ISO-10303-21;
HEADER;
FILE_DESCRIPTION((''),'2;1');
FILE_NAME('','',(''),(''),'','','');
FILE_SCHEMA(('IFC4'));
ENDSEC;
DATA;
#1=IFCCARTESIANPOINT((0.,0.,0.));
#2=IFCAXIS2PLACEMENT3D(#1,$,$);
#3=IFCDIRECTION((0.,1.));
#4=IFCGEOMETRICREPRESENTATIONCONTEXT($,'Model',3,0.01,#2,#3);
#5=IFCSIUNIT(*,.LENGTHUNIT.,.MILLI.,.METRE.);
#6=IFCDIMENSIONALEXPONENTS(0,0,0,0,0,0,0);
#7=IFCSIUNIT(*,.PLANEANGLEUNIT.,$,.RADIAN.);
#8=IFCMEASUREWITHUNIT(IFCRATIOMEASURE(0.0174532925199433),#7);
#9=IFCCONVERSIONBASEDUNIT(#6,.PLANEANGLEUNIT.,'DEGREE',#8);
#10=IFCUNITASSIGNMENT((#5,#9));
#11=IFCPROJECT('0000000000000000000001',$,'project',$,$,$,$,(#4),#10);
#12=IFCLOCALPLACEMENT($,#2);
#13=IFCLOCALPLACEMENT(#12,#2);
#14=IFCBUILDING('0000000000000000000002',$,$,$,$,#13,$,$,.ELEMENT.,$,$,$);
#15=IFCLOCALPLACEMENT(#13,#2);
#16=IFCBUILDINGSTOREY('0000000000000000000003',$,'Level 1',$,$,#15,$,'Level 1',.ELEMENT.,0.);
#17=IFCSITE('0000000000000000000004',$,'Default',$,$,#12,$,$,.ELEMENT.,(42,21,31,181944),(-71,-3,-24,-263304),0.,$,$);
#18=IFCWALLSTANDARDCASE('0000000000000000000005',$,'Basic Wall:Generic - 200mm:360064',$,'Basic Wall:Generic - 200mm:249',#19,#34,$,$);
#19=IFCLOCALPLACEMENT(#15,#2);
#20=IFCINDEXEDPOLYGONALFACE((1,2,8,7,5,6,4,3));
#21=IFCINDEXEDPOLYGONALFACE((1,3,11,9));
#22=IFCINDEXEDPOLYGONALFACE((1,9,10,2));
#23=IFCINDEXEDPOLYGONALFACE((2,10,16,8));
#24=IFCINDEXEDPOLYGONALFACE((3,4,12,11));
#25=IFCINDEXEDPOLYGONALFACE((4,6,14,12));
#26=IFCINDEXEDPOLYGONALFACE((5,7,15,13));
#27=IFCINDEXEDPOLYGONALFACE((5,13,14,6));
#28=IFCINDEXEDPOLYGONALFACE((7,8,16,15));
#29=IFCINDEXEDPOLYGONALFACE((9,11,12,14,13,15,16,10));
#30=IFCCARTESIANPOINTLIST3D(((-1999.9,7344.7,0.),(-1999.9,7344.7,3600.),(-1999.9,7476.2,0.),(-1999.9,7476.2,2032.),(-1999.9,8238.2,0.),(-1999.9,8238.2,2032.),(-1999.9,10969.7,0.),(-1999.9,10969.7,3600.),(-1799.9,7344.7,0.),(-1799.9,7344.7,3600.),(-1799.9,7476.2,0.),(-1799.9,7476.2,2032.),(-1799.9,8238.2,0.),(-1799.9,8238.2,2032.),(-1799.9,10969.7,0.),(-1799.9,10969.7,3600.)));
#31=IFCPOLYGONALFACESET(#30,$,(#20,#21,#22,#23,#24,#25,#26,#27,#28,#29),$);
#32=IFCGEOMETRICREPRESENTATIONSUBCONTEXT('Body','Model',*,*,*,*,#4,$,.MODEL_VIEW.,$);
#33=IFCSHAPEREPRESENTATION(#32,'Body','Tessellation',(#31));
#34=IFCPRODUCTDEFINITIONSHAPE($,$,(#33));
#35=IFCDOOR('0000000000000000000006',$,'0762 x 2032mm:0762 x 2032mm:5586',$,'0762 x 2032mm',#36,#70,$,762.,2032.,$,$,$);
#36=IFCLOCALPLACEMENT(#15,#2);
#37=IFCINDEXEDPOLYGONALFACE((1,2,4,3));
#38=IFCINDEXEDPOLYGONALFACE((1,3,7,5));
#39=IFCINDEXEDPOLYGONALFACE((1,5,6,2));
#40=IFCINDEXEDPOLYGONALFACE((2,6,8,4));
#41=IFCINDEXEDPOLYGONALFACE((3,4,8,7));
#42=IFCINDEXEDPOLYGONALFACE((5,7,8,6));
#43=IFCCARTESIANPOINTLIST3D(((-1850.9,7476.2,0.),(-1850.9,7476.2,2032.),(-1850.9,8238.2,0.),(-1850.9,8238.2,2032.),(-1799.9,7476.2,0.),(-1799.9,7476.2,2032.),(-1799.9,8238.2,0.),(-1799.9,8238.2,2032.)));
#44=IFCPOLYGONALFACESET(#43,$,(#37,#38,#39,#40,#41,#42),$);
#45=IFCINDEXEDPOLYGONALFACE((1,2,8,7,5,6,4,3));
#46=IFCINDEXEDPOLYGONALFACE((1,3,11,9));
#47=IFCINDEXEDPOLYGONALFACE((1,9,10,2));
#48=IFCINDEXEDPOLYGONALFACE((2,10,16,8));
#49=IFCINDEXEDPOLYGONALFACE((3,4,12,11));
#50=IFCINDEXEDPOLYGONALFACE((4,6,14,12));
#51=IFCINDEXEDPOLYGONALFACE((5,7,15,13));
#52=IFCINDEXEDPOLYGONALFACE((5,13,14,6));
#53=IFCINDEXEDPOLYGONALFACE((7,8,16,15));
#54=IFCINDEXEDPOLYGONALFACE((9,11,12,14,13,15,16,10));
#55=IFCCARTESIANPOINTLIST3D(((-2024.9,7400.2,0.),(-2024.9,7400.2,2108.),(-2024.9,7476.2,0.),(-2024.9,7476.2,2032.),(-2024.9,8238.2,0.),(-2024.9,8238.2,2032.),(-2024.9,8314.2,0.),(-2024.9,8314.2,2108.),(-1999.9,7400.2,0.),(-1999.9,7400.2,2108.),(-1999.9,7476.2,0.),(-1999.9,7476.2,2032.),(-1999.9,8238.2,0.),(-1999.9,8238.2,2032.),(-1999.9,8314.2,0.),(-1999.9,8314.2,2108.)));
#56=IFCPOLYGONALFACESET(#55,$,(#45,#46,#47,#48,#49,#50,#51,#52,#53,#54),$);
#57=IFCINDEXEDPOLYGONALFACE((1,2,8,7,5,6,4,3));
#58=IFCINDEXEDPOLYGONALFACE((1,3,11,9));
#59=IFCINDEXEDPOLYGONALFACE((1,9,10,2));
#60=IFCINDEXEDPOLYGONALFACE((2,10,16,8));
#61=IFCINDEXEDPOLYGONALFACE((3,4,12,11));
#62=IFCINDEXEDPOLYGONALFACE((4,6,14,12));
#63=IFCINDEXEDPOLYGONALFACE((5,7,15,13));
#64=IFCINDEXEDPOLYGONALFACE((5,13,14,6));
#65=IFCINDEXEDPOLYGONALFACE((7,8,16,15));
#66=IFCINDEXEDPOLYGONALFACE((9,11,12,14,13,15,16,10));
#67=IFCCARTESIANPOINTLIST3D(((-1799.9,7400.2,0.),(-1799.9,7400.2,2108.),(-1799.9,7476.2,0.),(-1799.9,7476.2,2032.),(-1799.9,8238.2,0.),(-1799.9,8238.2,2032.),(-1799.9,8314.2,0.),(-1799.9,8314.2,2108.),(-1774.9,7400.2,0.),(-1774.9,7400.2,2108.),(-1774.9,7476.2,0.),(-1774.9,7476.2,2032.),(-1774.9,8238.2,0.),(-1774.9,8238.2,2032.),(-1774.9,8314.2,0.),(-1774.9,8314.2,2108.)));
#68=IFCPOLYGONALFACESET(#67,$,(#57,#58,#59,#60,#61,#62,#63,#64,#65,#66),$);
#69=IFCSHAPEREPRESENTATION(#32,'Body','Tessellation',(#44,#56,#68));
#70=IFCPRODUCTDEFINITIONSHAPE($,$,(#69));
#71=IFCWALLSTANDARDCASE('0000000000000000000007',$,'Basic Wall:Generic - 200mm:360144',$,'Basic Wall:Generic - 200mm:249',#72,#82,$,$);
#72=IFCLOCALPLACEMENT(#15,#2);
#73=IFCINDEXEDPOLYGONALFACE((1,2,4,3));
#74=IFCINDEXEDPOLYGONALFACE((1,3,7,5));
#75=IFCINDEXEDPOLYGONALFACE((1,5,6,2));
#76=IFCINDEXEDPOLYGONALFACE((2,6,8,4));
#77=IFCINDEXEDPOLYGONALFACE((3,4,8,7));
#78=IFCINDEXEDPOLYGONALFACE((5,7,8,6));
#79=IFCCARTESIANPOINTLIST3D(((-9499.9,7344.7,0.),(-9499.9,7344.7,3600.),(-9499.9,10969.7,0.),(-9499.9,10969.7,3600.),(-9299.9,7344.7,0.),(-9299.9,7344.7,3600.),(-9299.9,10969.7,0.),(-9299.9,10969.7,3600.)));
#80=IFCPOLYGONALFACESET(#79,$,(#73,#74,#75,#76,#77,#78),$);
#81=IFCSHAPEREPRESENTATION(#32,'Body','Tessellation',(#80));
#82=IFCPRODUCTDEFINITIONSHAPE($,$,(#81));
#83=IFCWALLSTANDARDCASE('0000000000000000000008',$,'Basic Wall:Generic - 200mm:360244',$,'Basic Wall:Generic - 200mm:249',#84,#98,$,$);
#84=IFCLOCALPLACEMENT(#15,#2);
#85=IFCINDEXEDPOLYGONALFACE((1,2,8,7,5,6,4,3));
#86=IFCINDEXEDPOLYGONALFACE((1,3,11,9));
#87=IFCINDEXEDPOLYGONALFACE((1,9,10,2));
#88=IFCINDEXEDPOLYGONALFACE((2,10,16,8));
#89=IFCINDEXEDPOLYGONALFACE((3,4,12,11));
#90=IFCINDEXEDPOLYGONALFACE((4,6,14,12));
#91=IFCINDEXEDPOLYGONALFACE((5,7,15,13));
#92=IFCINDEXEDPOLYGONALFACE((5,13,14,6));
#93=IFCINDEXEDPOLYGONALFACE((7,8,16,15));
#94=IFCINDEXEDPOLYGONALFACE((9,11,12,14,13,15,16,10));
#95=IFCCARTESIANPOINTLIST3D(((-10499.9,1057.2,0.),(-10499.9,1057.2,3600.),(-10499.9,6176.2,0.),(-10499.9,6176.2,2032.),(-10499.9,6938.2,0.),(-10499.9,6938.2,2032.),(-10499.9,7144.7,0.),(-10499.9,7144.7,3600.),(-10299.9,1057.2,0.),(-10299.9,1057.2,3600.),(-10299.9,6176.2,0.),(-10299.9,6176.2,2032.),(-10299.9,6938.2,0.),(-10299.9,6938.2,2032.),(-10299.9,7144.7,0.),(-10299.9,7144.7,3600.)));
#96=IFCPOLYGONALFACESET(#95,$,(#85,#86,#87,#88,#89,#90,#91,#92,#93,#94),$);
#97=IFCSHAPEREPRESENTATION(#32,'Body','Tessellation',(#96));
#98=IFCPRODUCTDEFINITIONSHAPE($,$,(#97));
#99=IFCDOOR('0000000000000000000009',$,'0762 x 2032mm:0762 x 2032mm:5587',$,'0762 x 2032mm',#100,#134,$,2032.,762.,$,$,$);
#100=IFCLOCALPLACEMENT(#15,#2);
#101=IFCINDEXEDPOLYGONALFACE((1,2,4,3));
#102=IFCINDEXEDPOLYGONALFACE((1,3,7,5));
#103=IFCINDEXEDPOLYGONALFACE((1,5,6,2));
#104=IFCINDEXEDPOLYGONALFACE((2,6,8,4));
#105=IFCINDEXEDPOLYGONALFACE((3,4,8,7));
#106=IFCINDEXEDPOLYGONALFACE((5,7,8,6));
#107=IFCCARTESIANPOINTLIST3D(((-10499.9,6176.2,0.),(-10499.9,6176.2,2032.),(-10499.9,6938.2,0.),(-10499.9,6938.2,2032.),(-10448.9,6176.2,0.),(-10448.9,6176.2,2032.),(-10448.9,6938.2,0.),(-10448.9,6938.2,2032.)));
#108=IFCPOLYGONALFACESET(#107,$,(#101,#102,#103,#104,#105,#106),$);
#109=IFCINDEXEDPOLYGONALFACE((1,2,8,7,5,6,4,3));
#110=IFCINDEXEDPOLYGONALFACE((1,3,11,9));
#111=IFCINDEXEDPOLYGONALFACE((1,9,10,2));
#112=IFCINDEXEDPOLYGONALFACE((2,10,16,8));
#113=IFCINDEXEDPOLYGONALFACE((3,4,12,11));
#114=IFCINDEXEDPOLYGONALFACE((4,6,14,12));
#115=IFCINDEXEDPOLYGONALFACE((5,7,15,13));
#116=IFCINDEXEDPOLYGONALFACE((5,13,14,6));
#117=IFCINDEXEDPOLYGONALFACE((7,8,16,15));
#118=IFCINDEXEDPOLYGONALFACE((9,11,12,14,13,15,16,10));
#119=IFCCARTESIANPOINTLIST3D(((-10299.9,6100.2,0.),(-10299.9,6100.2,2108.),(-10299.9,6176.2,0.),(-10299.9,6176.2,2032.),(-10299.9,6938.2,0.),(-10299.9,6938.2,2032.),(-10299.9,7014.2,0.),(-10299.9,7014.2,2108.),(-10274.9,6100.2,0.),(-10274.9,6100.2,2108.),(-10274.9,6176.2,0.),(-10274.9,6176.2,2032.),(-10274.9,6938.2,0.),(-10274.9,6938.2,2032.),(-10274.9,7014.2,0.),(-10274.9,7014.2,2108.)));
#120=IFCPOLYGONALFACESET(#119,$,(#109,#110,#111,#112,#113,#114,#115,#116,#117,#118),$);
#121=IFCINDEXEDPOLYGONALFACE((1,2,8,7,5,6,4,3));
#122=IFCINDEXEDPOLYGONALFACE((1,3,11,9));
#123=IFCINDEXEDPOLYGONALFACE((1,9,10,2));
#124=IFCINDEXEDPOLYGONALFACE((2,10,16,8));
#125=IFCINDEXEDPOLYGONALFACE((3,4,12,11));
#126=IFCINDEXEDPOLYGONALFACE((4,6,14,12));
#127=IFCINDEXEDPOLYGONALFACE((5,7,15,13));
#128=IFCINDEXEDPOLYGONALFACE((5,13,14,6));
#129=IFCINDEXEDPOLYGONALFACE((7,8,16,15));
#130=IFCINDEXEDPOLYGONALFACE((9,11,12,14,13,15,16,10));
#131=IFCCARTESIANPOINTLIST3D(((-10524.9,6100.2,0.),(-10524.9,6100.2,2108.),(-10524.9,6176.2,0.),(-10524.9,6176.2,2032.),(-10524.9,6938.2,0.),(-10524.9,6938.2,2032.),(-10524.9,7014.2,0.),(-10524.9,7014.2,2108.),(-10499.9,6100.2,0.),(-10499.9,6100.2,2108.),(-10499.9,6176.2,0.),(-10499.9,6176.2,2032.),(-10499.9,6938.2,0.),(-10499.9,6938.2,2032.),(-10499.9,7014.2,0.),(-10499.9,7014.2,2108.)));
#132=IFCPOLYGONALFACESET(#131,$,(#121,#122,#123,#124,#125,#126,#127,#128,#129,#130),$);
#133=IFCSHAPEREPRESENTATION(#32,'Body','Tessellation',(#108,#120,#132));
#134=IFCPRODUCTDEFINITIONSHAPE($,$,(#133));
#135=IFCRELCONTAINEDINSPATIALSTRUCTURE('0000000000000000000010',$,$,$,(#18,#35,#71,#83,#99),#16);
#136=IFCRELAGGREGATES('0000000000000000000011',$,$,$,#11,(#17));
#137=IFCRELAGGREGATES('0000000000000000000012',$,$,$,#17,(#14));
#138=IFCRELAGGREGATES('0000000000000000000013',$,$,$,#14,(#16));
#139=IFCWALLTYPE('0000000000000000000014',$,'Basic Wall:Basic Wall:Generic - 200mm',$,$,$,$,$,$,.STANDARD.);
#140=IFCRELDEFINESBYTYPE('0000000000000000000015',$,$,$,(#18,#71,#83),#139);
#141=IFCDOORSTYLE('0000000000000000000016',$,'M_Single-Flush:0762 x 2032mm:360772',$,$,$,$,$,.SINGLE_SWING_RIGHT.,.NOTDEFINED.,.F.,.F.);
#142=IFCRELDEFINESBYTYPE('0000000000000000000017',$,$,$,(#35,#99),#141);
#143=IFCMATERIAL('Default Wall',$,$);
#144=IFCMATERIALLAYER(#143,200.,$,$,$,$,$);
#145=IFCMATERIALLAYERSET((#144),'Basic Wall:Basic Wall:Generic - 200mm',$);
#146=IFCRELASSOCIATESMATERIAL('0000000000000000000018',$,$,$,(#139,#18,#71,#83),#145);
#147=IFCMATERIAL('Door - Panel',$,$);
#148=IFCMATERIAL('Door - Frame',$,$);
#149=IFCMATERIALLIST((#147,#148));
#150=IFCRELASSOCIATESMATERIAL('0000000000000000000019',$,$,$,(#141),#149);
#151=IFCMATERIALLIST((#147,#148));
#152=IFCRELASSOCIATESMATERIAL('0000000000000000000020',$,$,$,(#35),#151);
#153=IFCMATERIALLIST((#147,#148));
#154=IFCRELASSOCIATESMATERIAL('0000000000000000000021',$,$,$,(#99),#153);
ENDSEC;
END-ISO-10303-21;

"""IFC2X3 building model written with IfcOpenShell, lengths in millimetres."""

from ifc_helpers import new_model, entity, si_unit, converted_unit, direction, frame, frame_2d, origin, origin_2d_with_axis, place, context, subcontext, project, spatial, polyline, rectangle, outline, extrude, source, transform, mapped, material, material_list, layer, layer_set, layer_usage, type_object, type_shapes, element, fill, save


model = new_model("IFC2X3")

# Units and contexts
model_context = context("Model", 3, precision=0.01, world=origin(), true_north=direction((0.0, 1.0)))
body_context = subcontext(model_context, "Body", "Model", "MODEL_VIEW")
ifc_project = project(units=[si_unit("LENGTHUNIT", "METRE", prefix="MILLI"), converted_unit("PLANEANGLEUNIT", "DEGREE", entity("IfcRatioMeasure", 0.0174532925199433), si_unit("PLANEANGLEUNIT", "RADIAN"), dimensions=[0, 0, 0, 0, 0, 0, 0])], contexts=[model_context])

# Site, building, storey
site_placement = place(None, origin())
site = spatial("IfcSite", under=ifc_project, at=site_placement, Name="Default", CompositionType="ELEMENT", RefLatitude=(42, 21, 31, 181944), RefLongitude=(-71, -3, -24, -263304), RefElevation=0.0)
building_placement = place(site_placement, origin())
building = spatial("IfcBuilding", under=site, at=building_placement, CompositionType="ELEMENT")
storey_placement = place(building_placement, origin())
storey = spatial("IfcBuildingStorey", under=building, at=storey_placement, Name="Level 1", LongName="Level 1", CompositionType="ELEMENT", Elevation=0.0)

# Shared definitions
ifc_material_1 = material(Name="Default Wall")
ifc_material_2 = material(Name="Door - Panel")
ifc_material_3 = material(Name="Door - Frame")

# Shared definitions
ifc_layer_1 = layer(ifc_material_1, 200.0)
ifc_layer_set_1 = layer_set([ifc_layer_1], Name="Basic Wall:Basic Wall:Generic - 200mm")
wall_type_1 = type_object("IfcWallType", Name="Basic Wall:Basic Wall:Generic - 200mm", PredefinedType="STANDARD", material=ifc_layer_set_1)

# Shared definitions
ifc_material_list_1 = material_list([ifc_material_2, ifc_material_3])
door_style_1 = type_object("IfcDoorStyle", Name="M_Single-Flush:0762 x 2032mm:360772", ConstructionType="NOTDEFINED", OperationType="SINGLE_SWING_RIGHT", ParameterTakesPrecedence=False, Sizeable=False, material=ifc_material_list_1)
shared_shape_1 = source(origin(), body_context, "Body", "SweptSolid", [
    extrude(rectangle(XDim=762.0, YDim=51.0, at=frame_2d((0.0, 0.0), x_axis=(1.0, 0.0))), frame((381.0, -27.5, 0.0), z_axis=(0.0, 0.0, 1.0), x_axis=(-1.0, 0.0, 0.0)), (0.0, 0.0, 1.0), 2032.0),
    extrude(outline(polyline([(-457.0, -1035.0), (-381.0, -1035.0), (-381.0, 997.0), (381.0, 997.0), (381.0, -1035.0), (457.0, -1035.0), (457.0, 1073.0), (-457.0, 1073.0), (-457.0, -1035.0)])), frame((381.0, -227.0, 1035.0), z_axis=(0.0, 1.0, 0.0), x_axis=(-1.0, 0.0, 0.0)), (0.0, 0.0, 1.0), 25.0),
    extrude(outline(polyline([(-1073.0, -457.0), (1035.0, -457.0), (1035.0, -381.0), (-997.0, -381.0), (-997.0, 381.0), (1035.0, 381.0), (1035.0, 457.0), (-1073.0, 457.0), (-1073.0, -457.0)])), frame((381.0, -2.0, 1035.0), z_axis=(0.0, 1.0, 0.0), x_axis=(0.0, 0.0, -1.0)), (0.0, 0.0, 1.0), 25.0),
])
type_shapes(door_style_1, [shared_shape_1])

# Wall, opening, door
ifc_layer_usage_1 = layer_usage(ifc_layer_set_1, "AXIS2", "NEGATIVE", 100.0)
wall_1_placement = place(storey_placement, frame((-1899.9, 10969.7, 0.0), z_axis=(0.0, 0.0, 1.0), x_axis=(0.0, -1.0, 0.0)))
wall_1 = element("IfcWallStandardCase", 1, at=wall_1_placement, inside=storey, type_object=wall_type_1, material=ifc_layer_usage_1, Name="Basic Wall:Generic - 200mm:360064", ObjectType="Basic Wall:Generic - 200mm:249", context=body_context, shape_type="SweptSolid", body=[
    extrude(rectangle(XDim=3625.0, YDim=200.0, at=frame_2d((1812.5, 0.0), x_axis=(-1.0, 0.0))), origin(), (0.0, 0.0, 1.0), 3600.0),
])
opening_1_placement = place(wall_1_placement, frame((10969.7, 1899.9, 0.0), z_axis=(0.0, 0.0, 1.0), x_axis=(0.0, 1.0, 0.0)))
opening_1 = element("IfcOpeningElement", 2, at=opening_1_placement, cuts=wall_1, ObjectType="Opening", context=body_context, shape_type="SweptSolid", body=[
    extrude(rectangle(XDim=2032.0, YDim=762.0, at=origin_2d_with_axis()), frame((-2001.9, 7857.2, 1016.0), z_axis=(1.0, 0.0, 0.0), x_axis=(0.0, 0.0, -1.0)), (0.0, 0.0, 1.0), 204.0),
])
ifc_material_list_2 = material_list([ifc_material_2, ifc_material_3])
door_1_placement = place(opening_1_placement, frame((-1797.9, 8238.2, 0.0), z_axis=(0.0, 0.0, 1.0), x_axis=(0.0, -1.0, 0.0)))
door_1 = element("IfcDoor", 3, at=door_1_placement, inside=storey, type_object=door_style_1, material=ifc_material_list_2, Name="0762 x 2032mm:0762 x 2032mm:5586", ObjectType="0762 x 2032mm", OverallHeight=762.0, OverallWidth=2032.0, context=body_context, shape_type="MappedRepresentation", body=[
    mapped(shared_shape_1, transform((0.0, 0.0, 0.0), scale=1.0)),
])
fill(opening_1, door_1)

# Wall
ifc_layer_usage_2 = layer_usage(ifc_layer_set_1, "AXIS2", "NEGATIVE", 100.0)
wall_2_placement = place(storey_placement, frame((-9399.9, 7344.7, 0.0), z_axis=(0.0, 0.0, 1.0), x_axis=(0.0, 1.0, 0.0)))
element("IfcWallStandardCase", 4, at=wall_2_placement, inside=storey, type_object=wall_type_1, material=ifc_layer_usage_2, Name="Basic Wall:Generic - 200mm:360144", ObjectType="Basic Wall:Generic - 200mm:249", context=body_context, shape_type="SweptSolid", body=[
    extrude(rectangle(XDim=3625.0, YDim=200.0, at=frame_2d((1812.5, 0.0), x_axis=(-1.0, 0.0))), origin(), (0.0, 0.0, 1.0), 3600.0),
])

# Wall, opening, door
ifc_layer_usage_3 = layer_usage(ifc_layer_set_1, "AXIS2", "NEGATIVE", 100.0)
wall_3_placement = place(storey_placement, frame((-10399.9, 7144.7, 0.0), z_axis=(0.0, 0.0, 1.0), x_axis=(0.0, -1.0, 0.0)))
wall_3 = element("IfcWallStandardCase", 5, at=wall_3_placement, inside=storey, type_object=wall_type_1, material=ifc_layer_usage_3, Name="Basic Wall:Generic - 200mm:360244", ObjectType="Basic Wall:Generic - 200mm:249", context=body_context, shape_type="SweptSolid", body=[
    extrude(rectangle(XDim=6087.5, YDim=200.0, at=frame_2d((3043.8, 0.0), x_axis=(-1.0, 0.0))), origin(), (0.0, 0.0, 1.0), 3600.0),
])
opening_2_placement = place(wall_3_placement, frame((7144.7, 10399.9, 0.0), z_axis=(0.0, 0.0, 1.0), x_axis=(0.0, 1.0, 0.0)))
opening_2 = element("IfcOpeningElement", 6, at=opening_2_placement, cuts=wall_3, ObjectType="Opening", context=body_context, shape_type="SweptSolid", body=[
    extrude(rectangle(XDim=2032.0, YDim=762.0, at=frame_2d((0.0, 0.0), x_axis=(0.0, 1.0))), frame((-10501.9, 6557.2, 1016.0), z_axis=(1.0, 0.0, 0.0), x_axis=(0.0, -1.0, 0.0)), (0.0, 0.0, 1.0), 204.0),
])
ifc_material_list_3 = material_list([ifc_material_2, ifc_material_3])
door_2_placement = place(opening_2_placement, frame((-10501.9, 6176.2, 0.0), z_axis=(0.0, 0.0, 1.0), x_axis=(0.0, 1.0, 0.0)))
door_2 = element("IfcDoor", 7, at=door_2_placement, inside=storey, type_object=door_style_1, material=ifc_material_list_3, Name="0762 x 2032mm:0762 x 2032mm:5587", ObjectType="0762 x 2032mm", OverallHeight=2032.0, OverallWidth=762.0, context=body_context, shape_type="MappedRepresentation", body=[
    mapped(shared_shape_1, transform((0.0, 0.0, 0.0), scale=1.0)),
])
fill(opening_2, door_2)

save(model, "model.ifc")
